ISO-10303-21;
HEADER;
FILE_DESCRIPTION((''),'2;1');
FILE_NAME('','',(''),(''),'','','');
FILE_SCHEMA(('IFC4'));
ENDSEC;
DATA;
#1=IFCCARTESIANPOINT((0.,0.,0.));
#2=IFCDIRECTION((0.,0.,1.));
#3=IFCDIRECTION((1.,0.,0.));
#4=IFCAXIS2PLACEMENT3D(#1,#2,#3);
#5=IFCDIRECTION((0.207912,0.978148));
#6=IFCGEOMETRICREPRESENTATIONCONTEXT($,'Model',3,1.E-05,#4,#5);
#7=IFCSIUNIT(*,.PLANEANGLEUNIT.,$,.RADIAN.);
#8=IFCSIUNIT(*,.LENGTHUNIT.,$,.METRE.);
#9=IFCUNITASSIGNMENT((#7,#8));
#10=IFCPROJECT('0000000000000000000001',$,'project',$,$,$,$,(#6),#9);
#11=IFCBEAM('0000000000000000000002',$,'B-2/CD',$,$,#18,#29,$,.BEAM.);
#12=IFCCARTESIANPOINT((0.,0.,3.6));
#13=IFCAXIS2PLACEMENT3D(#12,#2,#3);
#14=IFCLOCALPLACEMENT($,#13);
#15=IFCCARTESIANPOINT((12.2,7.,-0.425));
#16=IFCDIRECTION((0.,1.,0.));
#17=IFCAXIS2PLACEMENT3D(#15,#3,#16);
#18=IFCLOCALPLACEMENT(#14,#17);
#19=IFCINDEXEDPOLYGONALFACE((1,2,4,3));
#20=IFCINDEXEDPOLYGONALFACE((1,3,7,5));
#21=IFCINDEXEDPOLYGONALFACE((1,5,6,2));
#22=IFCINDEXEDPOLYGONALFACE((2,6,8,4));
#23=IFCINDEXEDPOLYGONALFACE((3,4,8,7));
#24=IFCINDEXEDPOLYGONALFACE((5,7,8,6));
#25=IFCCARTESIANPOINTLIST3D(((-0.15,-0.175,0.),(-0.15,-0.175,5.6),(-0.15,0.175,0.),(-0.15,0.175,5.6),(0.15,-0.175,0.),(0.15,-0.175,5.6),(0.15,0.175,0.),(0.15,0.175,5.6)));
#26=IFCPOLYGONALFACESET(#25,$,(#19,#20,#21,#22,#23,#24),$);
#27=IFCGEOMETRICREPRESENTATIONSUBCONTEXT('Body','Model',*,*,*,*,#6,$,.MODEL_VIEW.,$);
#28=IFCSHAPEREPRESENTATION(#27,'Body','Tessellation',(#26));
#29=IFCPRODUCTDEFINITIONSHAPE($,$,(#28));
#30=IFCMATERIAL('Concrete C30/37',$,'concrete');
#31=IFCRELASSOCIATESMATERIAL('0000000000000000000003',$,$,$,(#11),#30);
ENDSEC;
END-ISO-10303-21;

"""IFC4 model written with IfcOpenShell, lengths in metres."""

from ifc_helpers import new_model, si_unit, direction, frame, origin_with_axes, place, context, subcontext, project, rectangle, extrude, material, element, save


model = new_model("IFC4")

# Units and contexts
model_context = context("Model", 3, precision=1e-05, world=origin_with_axes(), true_north=direction((0.207912, 0.978148)))
body_context = subcontext(model_context, "Body", "Model", "MODEL_VIEW")
ifc_project = project(units=[si_unit("PLANEANGLEUNIT", "RADIAN"), si_unit("LENGTHUNIT", "METRE")], contexts=[model_context])

# Beam
ifc_material = material(Name="Concrete C30/37", Category="concrete")
placement = place(None, frame((0.0, 0.0, 3.6), z_axis=(0.0, 0.0, 1.0), x_axis=(1.0, 0.0, 0.0)))
beam_placement = place(placement, frame((12.2, 7.0, -0.425), z_axis=(1.0, 0.0, 0.0), x_axis=(0.0, 1.0, 0.0)))
element("IfcBeam", 1, at=beam_placement, material=ifc_material, Name="B-2/CD", PredefinedType="BEAM", context=body_context, shape_type="SweptSolid", body=[
    extrude(rectangle(XDim=0.3, YDim=0.35), origin_with_axes(), (0.0, 0.0, 1.0), 5.6),
])

save(model, "model.ifc")
